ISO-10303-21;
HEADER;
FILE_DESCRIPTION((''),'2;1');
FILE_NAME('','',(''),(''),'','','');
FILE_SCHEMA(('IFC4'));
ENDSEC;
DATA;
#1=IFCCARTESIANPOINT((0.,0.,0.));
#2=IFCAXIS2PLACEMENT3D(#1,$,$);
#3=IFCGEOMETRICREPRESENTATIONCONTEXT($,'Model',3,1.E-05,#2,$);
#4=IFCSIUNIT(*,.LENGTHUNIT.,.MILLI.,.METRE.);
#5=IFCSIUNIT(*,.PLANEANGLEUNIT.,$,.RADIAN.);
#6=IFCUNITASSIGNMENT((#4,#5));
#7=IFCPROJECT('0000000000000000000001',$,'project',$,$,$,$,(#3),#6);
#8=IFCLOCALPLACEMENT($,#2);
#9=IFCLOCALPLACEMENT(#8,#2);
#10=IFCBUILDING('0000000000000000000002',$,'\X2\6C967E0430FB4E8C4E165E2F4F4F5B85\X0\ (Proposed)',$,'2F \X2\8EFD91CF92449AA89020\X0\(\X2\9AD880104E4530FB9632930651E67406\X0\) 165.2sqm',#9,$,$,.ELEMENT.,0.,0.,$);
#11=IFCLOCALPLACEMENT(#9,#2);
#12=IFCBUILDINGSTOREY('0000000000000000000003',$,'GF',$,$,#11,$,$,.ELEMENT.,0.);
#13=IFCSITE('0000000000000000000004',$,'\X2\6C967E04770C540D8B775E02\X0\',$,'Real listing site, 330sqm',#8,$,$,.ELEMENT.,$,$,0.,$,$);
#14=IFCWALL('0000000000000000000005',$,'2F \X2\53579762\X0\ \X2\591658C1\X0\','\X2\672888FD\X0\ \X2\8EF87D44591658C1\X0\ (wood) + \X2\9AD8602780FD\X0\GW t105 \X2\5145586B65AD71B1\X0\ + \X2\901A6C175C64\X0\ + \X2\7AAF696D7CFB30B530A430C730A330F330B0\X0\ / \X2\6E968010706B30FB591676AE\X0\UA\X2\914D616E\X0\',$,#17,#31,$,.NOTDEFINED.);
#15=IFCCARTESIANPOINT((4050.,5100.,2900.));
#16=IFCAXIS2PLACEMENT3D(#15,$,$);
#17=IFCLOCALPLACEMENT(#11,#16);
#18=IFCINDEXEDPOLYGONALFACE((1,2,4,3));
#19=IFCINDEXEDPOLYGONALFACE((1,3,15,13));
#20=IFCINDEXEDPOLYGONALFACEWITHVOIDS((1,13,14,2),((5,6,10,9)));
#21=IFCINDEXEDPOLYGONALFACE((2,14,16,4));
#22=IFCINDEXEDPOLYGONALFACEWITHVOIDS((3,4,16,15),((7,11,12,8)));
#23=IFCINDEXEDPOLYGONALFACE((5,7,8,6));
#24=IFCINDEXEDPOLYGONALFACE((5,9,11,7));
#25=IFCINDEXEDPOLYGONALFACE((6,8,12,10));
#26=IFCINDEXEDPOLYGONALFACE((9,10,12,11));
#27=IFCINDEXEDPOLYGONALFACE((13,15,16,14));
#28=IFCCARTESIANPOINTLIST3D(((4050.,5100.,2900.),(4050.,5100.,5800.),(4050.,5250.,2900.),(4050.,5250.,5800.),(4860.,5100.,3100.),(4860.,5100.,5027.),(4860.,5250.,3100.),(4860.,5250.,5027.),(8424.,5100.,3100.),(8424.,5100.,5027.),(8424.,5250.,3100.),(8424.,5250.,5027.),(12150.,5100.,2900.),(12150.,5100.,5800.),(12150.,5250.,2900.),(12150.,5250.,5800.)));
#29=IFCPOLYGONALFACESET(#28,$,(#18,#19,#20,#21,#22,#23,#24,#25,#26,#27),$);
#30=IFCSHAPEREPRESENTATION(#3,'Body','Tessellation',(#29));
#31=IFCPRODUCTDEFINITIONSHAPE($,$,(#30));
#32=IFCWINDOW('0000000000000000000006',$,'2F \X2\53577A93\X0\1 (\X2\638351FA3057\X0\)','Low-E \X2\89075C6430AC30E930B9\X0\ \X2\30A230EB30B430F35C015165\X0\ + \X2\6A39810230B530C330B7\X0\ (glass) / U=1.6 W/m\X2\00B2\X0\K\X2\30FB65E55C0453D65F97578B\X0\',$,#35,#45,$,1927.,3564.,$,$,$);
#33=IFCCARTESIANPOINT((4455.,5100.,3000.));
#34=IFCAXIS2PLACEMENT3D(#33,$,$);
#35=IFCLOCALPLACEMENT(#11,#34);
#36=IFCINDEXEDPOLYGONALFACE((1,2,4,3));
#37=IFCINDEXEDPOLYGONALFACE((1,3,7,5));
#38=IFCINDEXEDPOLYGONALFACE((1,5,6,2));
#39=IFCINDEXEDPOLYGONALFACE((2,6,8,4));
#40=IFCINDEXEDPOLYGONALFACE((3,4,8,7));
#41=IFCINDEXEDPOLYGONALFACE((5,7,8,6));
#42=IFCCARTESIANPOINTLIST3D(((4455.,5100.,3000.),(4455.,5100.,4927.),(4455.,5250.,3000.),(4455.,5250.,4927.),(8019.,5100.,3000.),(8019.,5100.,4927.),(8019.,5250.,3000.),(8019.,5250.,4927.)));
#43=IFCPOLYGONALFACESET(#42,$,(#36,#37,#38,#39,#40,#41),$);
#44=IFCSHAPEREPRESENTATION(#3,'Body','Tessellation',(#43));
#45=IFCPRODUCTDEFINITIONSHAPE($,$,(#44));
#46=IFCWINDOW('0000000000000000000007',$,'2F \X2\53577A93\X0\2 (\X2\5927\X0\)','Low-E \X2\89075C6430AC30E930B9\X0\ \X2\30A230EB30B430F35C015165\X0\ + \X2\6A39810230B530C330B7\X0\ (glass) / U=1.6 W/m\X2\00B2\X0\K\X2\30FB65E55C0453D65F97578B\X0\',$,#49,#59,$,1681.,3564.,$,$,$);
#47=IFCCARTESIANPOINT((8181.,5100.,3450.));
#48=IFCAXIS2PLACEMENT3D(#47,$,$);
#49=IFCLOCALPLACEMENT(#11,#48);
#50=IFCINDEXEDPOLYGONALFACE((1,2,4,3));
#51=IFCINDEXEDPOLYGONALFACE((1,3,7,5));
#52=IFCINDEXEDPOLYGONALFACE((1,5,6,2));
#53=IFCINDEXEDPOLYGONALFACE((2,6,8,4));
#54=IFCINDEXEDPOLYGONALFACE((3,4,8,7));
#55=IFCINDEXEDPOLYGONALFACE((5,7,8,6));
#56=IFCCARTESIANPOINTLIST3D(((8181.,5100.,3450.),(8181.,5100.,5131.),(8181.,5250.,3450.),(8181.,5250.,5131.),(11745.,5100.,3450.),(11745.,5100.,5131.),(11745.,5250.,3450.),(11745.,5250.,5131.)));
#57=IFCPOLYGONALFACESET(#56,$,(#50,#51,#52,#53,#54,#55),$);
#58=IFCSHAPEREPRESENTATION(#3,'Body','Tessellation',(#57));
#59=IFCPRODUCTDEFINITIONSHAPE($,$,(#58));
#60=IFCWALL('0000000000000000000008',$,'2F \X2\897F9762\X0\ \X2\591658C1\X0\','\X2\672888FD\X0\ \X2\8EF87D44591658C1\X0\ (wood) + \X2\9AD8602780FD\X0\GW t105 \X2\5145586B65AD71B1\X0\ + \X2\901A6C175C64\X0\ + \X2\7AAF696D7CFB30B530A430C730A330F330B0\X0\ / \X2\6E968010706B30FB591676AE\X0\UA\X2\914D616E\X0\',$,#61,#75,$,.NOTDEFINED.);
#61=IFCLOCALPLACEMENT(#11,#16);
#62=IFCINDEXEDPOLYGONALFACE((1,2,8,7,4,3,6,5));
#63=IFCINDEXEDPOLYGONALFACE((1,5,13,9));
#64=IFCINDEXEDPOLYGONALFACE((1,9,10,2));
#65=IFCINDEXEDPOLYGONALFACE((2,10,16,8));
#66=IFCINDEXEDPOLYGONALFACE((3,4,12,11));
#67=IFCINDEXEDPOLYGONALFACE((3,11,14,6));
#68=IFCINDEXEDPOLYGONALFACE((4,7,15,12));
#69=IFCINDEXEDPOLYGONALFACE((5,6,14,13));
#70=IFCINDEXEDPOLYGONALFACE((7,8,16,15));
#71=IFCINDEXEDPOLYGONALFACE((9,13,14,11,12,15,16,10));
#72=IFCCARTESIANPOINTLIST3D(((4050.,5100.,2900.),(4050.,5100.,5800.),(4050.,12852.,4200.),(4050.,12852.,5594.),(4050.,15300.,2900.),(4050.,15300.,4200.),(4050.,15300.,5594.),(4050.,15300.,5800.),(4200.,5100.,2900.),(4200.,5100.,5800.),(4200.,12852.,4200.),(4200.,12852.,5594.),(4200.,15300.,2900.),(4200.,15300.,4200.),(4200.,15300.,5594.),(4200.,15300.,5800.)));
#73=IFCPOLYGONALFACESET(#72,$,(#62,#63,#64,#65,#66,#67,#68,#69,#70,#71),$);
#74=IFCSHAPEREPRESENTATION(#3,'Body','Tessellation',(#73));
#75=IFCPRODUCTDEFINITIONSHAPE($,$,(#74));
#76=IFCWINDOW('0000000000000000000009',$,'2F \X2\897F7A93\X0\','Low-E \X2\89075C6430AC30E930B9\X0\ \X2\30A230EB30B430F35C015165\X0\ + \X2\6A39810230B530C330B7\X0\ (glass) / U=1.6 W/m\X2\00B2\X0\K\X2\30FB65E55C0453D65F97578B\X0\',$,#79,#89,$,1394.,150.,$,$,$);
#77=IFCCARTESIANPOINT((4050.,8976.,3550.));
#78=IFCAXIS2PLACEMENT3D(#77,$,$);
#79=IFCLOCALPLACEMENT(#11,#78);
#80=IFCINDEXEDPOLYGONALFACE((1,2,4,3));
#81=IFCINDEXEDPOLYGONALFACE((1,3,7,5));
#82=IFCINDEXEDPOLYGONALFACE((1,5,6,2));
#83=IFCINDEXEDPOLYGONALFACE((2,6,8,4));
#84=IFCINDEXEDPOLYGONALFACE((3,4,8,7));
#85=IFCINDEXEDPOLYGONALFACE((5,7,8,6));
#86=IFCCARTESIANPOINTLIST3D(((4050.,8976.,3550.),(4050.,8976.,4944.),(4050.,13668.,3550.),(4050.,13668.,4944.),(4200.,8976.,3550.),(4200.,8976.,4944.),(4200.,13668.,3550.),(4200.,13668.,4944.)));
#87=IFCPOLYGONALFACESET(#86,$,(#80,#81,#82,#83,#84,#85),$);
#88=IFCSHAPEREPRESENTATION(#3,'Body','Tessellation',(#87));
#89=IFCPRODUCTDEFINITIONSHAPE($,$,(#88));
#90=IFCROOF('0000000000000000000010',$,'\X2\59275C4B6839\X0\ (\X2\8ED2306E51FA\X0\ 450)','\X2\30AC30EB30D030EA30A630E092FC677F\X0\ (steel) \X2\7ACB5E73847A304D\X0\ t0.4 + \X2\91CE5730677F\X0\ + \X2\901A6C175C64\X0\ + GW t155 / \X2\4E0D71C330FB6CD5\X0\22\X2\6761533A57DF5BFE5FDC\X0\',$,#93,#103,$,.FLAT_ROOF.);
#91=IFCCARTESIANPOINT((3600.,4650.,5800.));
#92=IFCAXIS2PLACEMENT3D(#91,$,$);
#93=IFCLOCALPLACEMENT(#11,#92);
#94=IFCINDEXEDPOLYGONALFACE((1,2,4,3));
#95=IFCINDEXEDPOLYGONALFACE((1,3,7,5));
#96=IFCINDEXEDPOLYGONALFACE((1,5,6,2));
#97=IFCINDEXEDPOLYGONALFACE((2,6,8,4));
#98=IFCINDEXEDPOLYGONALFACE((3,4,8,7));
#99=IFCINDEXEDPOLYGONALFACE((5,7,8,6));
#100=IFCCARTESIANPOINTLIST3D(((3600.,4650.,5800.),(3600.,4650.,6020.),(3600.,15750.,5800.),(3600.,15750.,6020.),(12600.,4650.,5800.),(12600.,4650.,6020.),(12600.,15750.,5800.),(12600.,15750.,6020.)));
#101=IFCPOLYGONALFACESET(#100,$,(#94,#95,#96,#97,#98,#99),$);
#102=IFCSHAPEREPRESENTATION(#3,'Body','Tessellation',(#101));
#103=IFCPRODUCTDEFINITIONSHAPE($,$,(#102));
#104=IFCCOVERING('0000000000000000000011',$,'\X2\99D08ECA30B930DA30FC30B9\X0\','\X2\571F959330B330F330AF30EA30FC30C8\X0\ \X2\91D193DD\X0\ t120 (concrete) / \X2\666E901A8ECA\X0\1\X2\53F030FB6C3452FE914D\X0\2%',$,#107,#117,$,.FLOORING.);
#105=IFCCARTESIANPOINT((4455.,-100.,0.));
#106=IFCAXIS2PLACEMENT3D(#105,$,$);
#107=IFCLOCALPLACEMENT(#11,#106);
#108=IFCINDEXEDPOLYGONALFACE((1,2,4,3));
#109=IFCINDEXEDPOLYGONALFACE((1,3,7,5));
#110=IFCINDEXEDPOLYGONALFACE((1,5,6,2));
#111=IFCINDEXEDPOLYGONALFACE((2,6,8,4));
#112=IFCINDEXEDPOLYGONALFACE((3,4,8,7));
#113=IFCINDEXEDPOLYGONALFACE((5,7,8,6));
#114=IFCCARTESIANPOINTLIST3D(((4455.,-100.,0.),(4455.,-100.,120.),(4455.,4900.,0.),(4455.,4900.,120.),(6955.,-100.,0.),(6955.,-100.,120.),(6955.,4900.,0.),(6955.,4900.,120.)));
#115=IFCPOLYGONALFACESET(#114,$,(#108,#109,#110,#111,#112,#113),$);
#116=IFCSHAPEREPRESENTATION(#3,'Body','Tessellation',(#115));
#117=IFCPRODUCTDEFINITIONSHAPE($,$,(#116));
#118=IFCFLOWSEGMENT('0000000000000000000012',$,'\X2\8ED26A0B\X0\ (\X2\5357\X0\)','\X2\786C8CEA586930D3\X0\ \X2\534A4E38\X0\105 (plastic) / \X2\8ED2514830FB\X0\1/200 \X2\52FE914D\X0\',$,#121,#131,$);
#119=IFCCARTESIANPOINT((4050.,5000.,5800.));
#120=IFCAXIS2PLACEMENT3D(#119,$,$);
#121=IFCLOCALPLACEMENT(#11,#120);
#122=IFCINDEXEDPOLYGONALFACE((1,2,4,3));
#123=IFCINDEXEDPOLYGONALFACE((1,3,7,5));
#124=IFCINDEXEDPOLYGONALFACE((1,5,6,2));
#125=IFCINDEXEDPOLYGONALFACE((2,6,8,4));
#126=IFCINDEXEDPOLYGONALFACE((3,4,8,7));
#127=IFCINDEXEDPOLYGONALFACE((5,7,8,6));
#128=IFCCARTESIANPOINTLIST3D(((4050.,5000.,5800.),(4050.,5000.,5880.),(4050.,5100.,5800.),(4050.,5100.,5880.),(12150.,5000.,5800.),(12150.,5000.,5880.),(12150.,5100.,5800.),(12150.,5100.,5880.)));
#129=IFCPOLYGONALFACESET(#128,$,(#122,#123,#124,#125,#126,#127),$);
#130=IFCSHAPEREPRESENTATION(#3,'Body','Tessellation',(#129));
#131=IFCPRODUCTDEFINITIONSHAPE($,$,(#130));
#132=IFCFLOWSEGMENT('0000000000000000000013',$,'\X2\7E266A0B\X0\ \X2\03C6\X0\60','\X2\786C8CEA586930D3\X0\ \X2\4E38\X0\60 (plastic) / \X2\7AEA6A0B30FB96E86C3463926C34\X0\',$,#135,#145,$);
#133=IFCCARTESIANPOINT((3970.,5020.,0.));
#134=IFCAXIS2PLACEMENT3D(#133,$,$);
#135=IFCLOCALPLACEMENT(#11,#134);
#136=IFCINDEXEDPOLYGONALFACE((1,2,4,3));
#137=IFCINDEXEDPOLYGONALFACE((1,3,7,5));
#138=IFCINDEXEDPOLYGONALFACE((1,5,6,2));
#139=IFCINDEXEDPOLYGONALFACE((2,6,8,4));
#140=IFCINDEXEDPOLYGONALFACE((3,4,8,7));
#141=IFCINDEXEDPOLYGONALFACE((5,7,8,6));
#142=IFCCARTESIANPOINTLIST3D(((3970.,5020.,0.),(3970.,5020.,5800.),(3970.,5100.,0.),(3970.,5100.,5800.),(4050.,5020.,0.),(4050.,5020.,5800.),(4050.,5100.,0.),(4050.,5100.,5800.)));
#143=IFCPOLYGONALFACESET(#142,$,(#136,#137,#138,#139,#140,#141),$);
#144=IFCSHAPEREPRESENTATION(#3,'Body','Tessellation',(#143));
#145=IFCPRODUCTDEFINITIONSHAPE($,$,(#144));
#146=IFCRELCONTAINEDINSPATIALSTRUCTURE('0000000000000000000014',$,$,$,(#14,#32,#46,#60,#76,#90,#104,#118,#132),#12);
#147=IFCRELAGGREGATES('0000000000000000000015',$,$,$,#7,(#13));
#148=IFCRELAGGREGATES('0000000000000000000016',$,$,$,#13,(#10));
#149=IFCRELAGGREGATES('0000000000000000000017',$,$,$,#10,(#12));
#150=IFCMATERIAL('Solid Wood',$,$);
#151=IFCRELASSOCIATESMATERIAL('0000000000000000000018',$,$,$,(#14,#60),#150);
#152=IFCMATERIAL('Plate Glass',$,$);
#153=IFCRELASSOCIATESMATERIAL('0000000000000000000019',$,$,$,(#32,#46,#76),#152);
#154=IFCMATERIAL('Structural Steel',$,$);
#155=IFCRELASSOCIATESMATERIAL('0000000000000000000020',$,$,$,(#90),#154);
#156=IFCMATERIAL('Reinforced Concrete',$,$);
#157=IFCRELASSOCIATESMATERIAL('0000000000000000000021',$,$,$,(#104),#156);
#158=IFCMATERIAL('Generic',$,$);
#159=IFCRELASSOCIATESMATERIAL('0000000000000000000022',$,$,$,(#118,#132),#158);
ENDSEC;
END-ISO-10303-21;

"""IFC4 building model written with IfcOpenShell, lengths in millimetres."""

from ifc_helpers import new_model, si_unit, frame, frame_2d, origin, place, context, project, spatial, rectangle, extrude, material, element, fill, save


model = new_model("IFC4")

# Units and contexts
model_context = context("Model", 3, precision=1e-05, world=origin())
ifc_project = project(units=[si_unit("LENGTHUNIT", "METRE", prefix="MILLI"), si_unit("PLANEANGLEUNIT", "RADIAN")], contexts=[model_context])

# Site, building, storey
site_placement = place(None, origin())
site = spatial("IfcSite", under=ifc_project, at=site_placement, Name="沖縄県名護市", ObjectType="Real listing site, 330sqm", CompositionType="ELEMENT", RefElevation=0.0)
building_placement = place(site_placement, origin())
building = spatial("IfcBuilding", under=site, at=building_placement, Name="沖縄・二世帯住宅 (Proposed)", ObjectType="2F 軽量鉄骨造(高耐久・防錆処理) 165.2sqm", CompositionType="ELEMENT", ElevationOfRefHeight=0.0, ElevationOfTerrain=0.0)
storey_placement = place(building_placement, origin())
storey = spatial("IfcBuildingStorey", under=building, at=storey_placement, Name="GF", CompositionType="ELEMENT", Elevation=0.0)

# Shared definitions
ifc_material_1 = material(Name="Solid Wood")

# Shared definitions
ifc_material_2 = material(Name="Reinforced Concrete")

# Shared definitions
ifc_material_3 = material(Name="Plate Glass")

# Wall, openings, windows
wall_1_placement = place(storey_placement, frame((4050.0, 5100.0, 2900.0)))
wall_1 = element("IfcWall", 1, at=wall_1_placement, inside=storey, material=ifc_material_1, Name="2F 南面 外壁", Description="木製 軸組外壁 (wood) + 高性能GW t105 充填断熱 + 通気層 + 窯業系サイディング / 準耐火・外皮UA配慮", PredefinedType="NOTDEFINED", context=model_context, shape_type="SweptSolid", body=[
    extrude(rectangle(XDim=8100.0, YDim=150.0, at=frame_2d((4050.0, 75.0))), frame((4050.0, 5100.0, 2900.0)), (0.0, 0.0, 1.0), 2900.0),
])
opening_1_placement = place(storey_placement, frame((4455.0, 5100.0, 3000.0)))
opening_1 = element("IfcOpeningElement", 2, at=opening_1_placement, cuts=wall_1, PredefinedType="NOTDEFINED", context=model_context, shape_type="SweptSolid", body=[
    extrude(rectangle(XDim=3564.0, YDim=150.0, at=frame_2d((1782.0, 75.0))), frame((4455.0, 5100.0, 3000.0)), (0.0, 0.0, 1.0), 1927.0),
])
opening_2_placement = place(storey_placement, frame((8181.0, 5100.0, 3450.0)))
opening_2 = element("IfcOpeningElement", 3, at=opening_2_placement, cuts=wall_1, PredefinedType="NOTDEFINED", context=model_context, shape_type="SweptSolid", body=[
    extrude(rectangle(XDim=3564.0, YDim=150.0, at=frame_2d((1782.0, 75.0))), frame((8181.0, 5100.0, 3450.0)), (0.0, 0.0, 1.0), 1681.0),
])
window_1_placement = place(storey_placement, frame((4455.0, 5100.0, 3000.0)))
window_1 = element("IfcWindow", 4, at=window_1_placement, inside=storey, material=ifc_material_3, Name="2F 南窓1 (掃出し)", Description="Low-E 複層ガラス アルゴン封入 + 樹脂サッシ (glass) / U=1.6 W/m²K・日射取得型", OverallHeight=1927.0, OverallWidth=3564.0, context=model_context, shape_type="SweptSolid", body=[
    extrude(rectangle(XDim=3564.0, YDim=150.0, at=frame_2d((1782.0, 75.0))), frame((4455.0, 5100.0, 3000.0)), (0.0, 0.0, 1.0), 1927.0),
])
fill(opening_1, window_1)
window_2_placement = place(storey_placement, frame((8181.0, 5100.0, 3450.0)))
window_2 = element("IfcWindow", 5, at=window_2_placement, inside=storey, material=ifc_material_3, Name="2F 南窓2 (大)", Description="Low-E 複層ガラス アルゴン封入 + 樹脂サッシ (glass) / U=1.6 W/m²K・日射取得型", OverallHeight=1681.0, OverallWidth=3564.0, context=model_context, shape_type="SweptSolid", body=[
    extrude(rectangle(XDim=3564.0, YDim=150.0, at=frame_2d((1782.0, 75.0))), frame((8181.0, 5100.0, 3450.0)), (0.0, 0.0, 1.0), 1681.0),
])
fill(opening_2, window_2)

# Wall, opening, window
wall_2_placement = place(storey_placement, frame((4050.0, 5100.0, 2900.0)))
wall_2 = element("IfcWall", 6, at=wall_2_placement, inside=storey, material=ifc_material_1, Name="2F 西面 外壁", Description="木製 軸組外壁 (wood) + 高性能GW t105 充填断熱 + 通気層 + 窯業系サイディング / 準耐火・外皮UA配慮", PredefinedType="NOTDEFINED", context=model_context, shape_type="SweptSolid", body=[
    extrude(rectangle(XDim=150.0, YDim=10200.0, at=frame_2d((75.0, 5100.0))), frame((4050.0, 5100.0, 2900.0)), (0.0, 0.0, 1.0), 2900.0),
])
opening_3_placement = place(storey_placement, frame((4050.0, 8976.0, 3550.0)))
opening_3 = element("IfcOpeningElement", 7, at=opening_3_placement, cuts=wall_2, PredefinedType="NOTDEFINED", context=model_context, shape_type="SweptSolid", body=[
    extrude(rectangle(XDim=150.0, YDim=4692.0, at=frame_2d((75.0, 2346.0))), frame((4050.0, 8976.0, 3550.0)), (0.0, 0.0, 1.0), 1394.0),
])
window_3_placement = place(storey_placement, frame((4050.0, 8976.0, 3550.0)))
window_3 = element("IfcWindow", 8, at=window_3_placement, inside=storey, material=ifc_material_3, Name="2F 西窓", Description="Low-E 複層ガラス アルゴン封入 + 樹脂サッシ (glass) / U=1.6 W/m²K・日射取得型", OverallHeight=1394.0, OverallWidth=150.0, context=model_context, shape_type="SweptSolid", body=[
    extrude(rectangle(XDim=150.0, YDim=4692.0, at=frame_2d((75.0, 2346.0))), frame((4050.0, 8976.0, 3550.0)), (0.0, 0.0, 1.0), 1394.0),
])
fill(opening_3, window_3)

# Roof
ifc_material_4 = material(Name="Structural Steel")
roof_placement = place(storey_placement, frame((3600.0, 4650.0, 5800.0)))
element("IfcRoof", 9, at=roof_placement, inside=storey, material=ifc_material_4, Name="大屋根 (軒の出 450)", Description="ガルバリウム鋼板 (steel) 立平葺き t0.4 + 野地板 + 通気層 + GW t155 / 不燃・法22条区域対応", PredefinedType="FLAT_ROOF", context=model_context, shape_type="SweptSolid", body=[
    extrude(rectangle(XDim=9000.0, YDim=11100.0, at=frame_2d((4500.0, 5550.0))), frame((3600.0, 4650.0, 5800.0)), (0.0, 0.0, 1.0), 220.0),
])

# Covering
covering_placement = place(storey_placement, frame((4455.0, -100.0, 0.0)))
element("IfcCovering", 10, at=covering_placement, inside=storey, material=ifc_material_2, Name="駐車スペース", Description="土間コンクリート 金鏝 t120 (concrete) / 普通車1台・水勾配2%", PredefinedType="FLOORING", context=model_context, shape_type="SweptSolid", body=[
    extrude(rectangle(XDim=2500.0, YDim=5000.0, at=frame_2d((1250.0, 2500.0))), frame((4455.0, -100.0, 0.0)), (0.0, 0.0, 1.0), 120.0),
])

# Flow segments
ifc_material_5 = material(Name="Generic")
flow_segment_1_placement = place(storey_placement, frame((4050.0, 5000.0, 5800.0)))
element("IfcFlowSegment", 11, at=flow_segment_1_placement, inside=storey, material=ifc_material_5, Name="軒樋 (南)", Description="硬質塩ビ 半丸105 (plastic) / 軒先・1/200 勾配", context=model_context, shape_type="SweptSolid", body=[
    extrude(rectangle(XDim=8100.0, YDim=100.0, at=frame_2d((4050.0, 50.0))), frame((4050.0, 5000.0, 5800.0)), (0.0, 0.0, 1.0), 80.0),
])
flow_segment_2_placement = place(storey_placement, frame((3970.0, 5020.0, 0.0)))
element("IfcFlowSegment", 12, at=flow_segment_2_placement, inside=storey, material=ifc_material_5, Name="縦樋 φ60", Description="硬質塩ビ 丸60 (plastic) / 竪樋・雨水排水", context=model_context, shape_type="SweptSolid", body=[
    extrude(rectangle(XDim=80.0, YDim=80.0, at=frame_2d((40.0, 40.0))), frame((3970.0, 5020.0, 0.0)), (0.0, 0.0, 1.0), 5800.0),
])

save(model, "model.ifc")
